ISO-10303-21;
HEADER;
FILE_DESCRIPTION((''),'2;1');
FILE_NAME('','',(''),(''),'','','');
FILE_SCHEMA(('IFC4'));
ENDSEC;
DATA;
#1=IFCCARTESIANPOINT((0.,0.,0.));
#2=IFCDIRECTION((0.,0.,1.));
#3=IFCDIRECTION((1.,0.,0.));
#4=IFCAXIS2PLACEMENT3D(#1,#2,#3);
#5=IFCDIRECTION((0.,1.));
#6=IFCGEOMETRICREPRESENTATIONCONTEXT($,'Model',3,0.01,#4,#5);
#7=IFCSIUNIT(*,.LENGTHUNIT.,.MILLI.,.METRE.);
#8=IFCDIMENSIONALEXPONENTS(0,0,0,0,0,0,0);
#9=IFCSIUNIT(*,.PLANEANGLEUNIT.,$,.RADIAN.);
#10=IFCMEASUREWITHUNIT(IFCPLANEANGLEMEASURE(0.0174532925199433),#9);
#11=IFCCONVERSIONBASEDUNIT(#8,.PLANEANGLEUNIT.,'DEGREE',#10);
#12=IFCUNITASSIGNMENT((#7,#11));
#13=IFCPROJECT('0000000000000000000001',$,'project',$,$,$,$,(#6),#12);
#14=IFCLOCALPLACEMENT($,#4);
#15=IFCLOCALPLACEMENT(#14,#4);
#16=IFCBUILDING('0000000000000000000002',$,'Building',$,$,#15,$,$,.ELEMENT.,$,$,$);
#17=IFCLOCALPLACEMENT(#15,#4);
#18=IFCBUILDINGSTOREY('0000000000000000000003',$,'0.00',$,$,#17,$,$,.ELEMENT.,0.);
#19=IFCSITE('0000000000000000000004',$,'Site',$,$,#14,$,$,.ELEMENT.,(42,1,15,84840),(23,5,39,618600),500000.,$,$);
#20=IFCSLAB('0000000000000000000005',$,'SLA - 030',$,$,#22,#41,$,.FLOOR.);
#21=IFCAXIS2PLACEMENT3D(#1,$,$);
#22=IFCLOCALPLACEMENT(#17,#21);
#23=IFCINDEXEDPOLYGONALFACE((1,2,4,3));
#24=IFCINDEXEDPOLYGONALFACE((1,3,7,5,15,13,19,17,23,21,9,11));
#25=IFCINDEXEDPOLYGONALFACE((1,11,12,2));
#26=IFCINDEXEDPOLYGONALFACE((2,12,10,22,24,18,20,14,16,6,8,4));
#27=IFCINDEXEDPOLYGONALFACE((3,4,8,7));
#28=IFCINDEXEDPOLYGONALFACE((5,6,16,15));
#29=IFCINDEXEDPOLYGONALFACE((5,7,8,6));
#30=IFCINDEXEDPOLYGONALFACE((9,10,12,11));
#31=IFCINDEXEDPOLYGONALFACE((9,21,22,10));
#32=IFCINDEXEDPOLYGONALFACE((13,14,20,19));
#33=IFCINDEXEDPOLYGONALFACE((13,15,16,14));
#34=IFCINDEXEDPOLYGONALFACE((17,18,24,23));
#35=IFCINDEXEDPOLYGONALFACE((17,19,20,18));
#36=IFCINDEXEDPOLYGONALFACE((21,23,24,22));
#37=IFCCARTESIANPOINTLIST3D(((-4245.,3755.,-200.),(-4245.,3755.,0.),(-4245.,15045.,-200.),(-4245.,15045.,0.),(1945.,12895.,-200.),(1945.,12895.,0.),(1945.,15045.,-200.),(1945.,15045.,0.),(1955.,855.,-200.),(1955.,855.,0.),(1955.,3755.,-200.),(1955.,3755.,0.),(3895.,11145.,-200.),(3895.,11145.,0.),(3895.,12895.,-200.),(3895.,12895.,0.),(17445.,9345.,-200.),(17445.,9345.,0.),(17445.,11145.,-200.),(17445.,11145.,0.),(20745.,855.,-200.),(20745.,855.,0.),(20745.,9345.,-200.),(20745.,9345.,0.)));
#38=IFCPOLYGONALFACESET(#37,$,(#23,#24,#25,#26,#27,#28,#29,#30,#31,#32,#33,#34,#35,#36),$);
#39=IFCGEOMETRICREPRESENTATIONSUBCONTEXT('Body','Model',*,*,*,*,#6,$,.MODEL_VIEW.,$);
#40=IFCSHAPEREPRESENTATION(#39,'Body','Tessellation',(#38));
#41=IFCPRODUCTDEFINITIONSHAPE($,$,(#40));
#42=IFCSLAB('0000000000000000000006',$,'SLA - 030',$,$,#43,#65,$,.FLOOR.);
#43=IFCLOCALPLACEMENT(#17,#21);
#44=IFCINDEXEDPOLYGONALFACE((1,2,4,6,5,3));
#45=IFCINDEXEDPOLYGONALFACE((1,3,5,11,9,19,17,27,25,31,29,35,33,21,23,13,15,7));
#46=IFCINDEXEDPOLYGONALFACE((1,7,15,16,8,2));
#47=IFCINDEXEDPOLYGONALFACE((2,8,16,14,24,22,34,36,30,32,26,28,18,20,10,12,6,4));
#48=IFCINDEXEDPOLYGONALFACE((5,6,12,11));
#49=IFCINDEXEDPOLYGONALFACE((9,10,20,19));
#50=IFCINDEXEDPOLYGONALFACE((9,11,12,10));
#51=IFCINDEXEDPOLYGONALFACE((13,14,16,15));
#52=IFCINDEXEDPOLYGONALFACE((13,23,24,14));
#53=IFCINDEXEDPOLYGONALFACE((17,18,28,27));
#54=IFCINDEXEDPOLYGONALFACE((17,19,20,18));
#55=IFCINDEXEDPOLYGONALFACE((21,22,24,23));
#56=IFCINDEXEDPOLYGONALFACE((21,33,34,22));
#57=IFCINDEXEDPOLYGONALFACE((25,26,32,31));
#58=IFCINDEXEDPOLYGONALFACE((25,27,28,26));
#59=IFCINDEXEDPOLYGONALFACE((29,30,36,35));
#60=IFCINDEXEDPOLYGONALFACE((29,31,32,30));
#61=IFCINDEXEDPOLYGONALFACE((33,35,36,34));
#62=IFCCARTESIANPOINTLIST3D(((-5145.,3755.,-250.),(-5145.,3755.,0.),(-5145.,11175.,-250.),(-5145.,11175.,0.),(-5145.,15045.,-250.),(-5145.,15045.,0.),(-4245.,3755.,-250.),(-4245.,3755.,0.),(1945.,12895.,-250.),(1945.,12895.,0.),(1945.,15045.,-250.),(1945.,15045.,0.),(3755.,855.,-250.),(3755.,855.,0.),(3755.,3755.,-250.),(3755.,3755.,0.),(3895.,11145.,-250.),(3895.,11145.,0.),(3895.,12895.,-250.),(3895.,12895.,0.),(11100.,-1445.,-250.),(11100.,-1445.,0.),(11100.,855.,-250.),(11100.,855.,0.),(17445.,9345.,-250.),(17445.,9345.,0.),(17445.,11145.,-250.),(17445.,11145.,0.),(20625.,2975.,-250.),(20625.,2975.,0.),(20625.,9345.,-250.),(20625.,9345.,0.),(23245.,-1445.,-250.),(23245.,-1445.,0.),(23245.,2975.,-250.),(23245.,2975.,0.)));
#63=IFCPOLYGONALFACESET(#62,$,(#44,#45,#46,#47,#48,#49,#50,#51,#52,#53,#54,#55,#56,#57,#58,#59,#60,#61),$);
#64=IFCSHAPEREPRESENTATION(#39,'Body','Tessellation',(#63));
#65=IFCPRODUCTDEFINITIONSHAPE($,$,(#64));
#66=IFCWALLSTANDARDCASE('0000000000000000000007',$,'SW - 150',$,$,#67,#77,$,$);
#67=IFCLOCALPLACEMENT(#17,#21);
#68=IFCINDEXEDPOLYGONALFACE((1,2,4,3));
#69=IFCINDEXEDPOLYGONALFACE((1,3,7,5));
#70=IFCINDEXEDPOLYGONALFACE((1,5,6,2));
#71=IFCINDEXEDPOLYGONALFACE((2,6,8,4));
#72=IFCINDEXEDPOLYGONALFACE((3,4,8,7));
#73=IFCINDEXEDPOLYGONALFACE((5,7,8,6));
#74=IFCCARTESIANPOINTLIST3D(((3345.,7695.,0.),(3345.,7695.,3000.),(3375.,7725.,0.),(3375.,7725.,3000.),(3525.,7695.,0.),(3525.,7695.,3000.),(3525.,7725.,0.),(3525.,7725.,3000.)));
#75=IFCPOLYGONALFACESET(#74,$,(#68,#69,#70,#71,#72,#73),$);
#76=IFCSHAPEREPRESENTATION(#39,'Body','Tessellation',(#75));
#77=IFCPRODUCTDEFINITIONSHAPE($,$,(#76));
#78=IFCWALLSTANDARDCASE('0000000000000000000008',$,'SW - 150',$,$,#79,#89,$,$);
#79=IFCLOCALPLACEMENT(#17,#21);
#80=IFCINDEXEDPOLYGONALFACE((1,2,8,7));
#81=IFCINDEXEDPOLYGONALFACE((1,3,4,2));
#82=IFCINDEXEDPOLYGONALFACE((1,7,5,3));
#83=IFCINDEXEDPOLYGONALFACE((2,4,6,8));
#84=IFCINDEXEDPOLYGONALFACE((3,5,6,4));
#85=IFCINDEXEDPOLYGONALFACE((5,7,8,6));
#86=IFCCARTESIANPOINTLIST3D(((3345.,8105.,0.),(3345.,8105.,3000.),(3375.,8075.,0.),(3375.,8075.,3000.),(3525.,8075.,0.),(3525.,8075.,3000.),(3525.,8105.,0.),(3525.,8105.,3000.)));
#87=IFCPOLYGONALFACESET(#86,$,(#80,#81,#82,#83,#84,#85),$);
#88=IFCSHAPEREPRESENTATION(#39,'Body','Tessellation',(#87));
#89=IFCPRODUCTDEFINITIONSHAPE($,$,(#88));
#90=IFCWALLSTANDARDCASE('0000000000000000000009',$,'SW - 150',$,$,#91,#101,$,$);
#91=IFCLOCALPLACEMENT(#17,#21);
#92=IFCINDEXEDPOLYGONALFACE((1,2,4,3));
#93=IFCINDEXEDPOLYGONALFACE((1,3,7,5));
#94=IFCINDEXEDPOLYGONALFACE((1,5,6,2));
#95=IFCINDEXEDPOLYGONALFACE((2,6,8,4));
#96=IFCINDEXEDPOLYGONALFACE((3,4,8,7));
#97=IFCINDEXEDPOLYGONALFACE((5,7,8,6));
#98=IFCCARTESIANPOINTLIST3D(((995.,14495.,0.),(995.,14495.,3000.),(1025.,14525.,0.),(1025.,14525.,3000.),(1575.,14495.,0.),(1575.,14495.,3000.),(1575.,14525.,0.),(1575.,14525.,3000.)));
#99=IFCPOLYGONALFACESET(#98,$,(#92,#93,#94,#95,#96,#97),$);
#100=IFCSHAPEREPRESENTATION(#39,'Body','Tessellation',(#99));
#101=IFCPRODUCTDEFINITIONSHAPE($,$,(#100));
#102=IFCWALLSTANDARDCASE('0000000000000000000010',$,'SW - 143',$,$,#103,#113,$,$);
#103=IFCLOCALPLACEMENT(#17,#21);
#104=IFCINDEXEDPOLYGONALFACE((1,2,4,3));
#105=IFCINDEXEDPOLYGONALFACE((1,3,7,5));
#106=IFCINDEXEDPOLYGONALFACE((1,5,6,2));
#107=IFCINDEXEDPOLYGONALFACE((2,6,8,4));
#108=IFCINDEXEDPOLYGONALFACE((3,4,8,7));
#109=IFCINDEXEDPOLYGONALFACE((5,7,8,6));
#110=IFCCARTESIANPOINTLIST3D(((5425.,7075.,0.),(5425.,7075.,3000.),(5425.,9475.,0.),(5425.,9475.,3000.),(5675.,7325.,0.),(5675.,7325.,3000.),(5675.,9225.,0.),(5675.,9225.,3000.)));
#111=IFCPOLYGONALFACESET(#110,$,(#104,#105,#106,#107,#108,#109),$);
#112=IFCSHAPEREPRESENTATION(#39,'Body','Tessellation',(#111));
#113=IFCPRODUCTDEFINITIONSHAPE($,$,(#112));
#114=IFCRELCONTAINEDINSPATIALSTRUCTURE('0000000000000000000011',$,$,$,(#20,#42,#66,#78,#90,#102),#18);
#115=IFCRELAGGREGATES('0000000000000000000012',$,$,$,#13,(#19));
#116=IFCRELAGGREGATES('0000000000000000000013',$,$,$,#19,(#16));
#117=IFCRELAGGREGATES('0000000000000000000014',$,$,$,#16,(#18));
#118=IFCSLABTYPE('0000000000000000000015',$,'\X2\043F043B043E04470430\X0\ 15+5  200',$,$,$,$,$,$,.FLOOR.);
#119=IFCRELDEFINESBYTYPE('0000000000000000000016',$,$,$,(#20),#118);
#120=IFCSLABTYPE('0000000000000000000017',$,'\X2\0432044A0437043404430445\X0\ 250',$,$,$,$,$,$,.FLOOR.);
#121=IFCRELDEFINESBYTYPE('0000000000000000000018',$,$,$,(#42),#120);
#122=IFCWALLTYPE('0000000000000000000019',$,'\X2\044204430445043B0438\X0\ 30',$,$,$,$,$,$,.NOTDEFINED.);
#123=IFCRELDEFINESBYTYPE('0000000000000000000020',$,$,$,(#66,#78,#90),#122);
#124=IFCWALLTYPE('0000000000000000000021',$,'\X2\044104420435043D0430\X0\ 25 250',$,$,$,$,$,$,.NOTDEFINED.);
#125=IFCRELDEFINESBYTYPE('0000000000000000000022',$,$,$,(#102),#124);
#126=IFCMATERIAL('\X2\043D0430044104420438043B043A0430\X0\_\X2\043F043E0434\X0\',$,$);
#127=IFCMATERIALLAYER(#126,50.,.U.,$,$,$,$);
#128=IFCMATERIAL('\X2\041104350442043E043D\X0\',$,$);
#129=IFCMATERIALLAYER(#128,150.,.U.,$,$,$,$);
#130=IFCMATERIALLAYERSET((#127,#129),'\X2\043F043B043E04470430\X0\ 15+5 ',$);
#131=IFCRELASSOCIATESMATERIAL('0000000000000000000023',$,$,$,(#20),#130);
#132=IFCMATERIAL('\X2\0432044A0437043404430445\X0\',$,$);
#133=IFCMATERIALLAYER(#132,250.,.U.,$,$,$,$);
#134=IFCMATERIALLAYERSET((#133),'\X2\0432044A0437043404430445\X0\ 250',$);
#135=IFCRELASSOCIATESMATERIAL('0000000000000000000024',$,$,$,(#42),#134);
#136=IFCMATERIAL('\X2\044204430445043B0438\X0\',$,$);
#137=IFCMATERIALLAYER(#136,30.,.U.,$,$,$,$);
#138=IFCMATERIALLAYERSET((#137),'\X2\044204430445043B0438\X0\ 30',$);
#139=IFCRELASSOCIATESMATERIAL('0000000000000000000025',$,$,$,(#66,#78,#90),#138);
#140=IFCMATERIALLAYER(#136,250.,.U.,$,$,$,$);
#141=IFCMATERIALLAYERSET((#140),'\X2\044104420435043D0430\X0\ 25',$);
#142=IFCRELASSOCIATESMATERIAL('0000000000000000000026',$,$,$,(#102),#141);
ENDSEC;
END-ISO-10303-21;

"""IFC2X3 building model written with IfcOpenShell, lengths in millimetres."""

from ifc_helpers import new_model, entity, si_unit, converted_unit, direction, frame, origin_with_axes, place, context, subcontext, project, spatial, polyline, outline, extrude, material, layer, layer_set, layer_usage, type_object, element, save


model = new_model("IFC2X3")

# Units and contexts
model_context = context("Model", 3, precision=0.01, world=origin_with_axes(), true_north=direction((0.0, 1.0)))
body_context = subcontext(model_context, "Body", "Model", "MODEL_VIEW")
ifc_project = project(units=[si_unit("LENGTHUNIT", "METRE", prefix="MILLI"), converted_unit("PLANEANGLEUNIT", "DEGREE", entity("IfcPlaneAngleMeasure", 0.0174532925199433), si_unit("PLANEANGLEUNIT", "RADIAN"), dimensions=[0, 0, 0, 0, 0, 0, 0])], contexts=[model_context])

# Site, building, storey
site_placement = place(None, origin_with_axes())
site = spatial("IfcSite", under=ifc_project, at=site_placement, Name="Site", CompositionType="ELEMENT", RefLatitude=(42, 1, 15, 84840), RefLongitude=(23, 5, 39, 618600), RefElevation=500000.0)
building_placement = place(site_placement, origin_with_axes())
building = spatial("IfcBuilding", under=site, at=building_placement, Name="Building", CompositionType="ELEMENT")
storey_placement = place(building_placement, origin_with_axes())
storey = spatial("IfcBuildingStorey", under=building, at=storey_placement, Name="0.00", CompositionType="ELEMENT", Elevation=0.0)

# Slabs
ifc_material_1 = material(Name="настилка_под")
ifc_layer_1 = layer(ifc_material_1, 50.0, ventilated="UNKNOWN")
ifc_material_2 = material(Name="Бетон")
ifc_layer_2 = layer(ifc_material_2, 150.0, ventilated="UNKNOWN")
ifc_layer_set_1 = layer_set([ifc_layer_1, ifc_layer_2], Name="плоча 15+5 ")
ifc_layer_usage_1 = layer_usage(ifc_layer_set_1, "AXIS3", "NEGATIVE", 200.0)
slab_type_1 = type_object("IfcSlabType", Name="плоча 15+5  200", PredefinedType="FLOOR")
slab_1_placement = place(storey_placement, frame((-4245.0, 15045.0, 0.0), z_axis=(0.0, 0.0, 1.0), x_axis=(1.0, 0.0, 0.0)))
element("IfcSlab", 1, at=slab_1_placement, inside=storey, type_object=slab_type_1, material=ifc_layer_usage_1, Name="SLA - 030", PredefinedType="FLOOR", context=body_context, shape_type="SweptSolid", body=[
    extrude(outline(polyline([(0.0, 0.0), (0.0, -11290.0), (6200.0, -11290.0), (6200.0, -14190.0), (24990.0, -14190.0), (24990.0, -5700.0), (21690.0, -5700.0), (21690.0, -3900.0), (8140.0, -3900.0), (8140.0, -2150.0), (6190.0, -2150.0), (6190.0, 0.0), (0.0, 0.0)])), frame((0.0, 0.0, -200.0), z_axis=(0.0, 0.0, 1.0), x_axis=(1.0, 0.0, 0.0)), (0.0, 0.0, 1.0), 200.0),
])
ifc_material_3 = material(Name="въздух")
ifc_layer_3 = layer(ifc_material_3, 250.0, ventilated="UNKNOWN")
ifc_layer_set_2 = layer_set([ifc_layer_3], Name="въздух 250")
ifc_layer_usage_2 = layer_usage(ifc_layer_set_2, "AXIS3", "NEGATIVE", 250.0)
slab_type_2 = type_object("IfcSlabType", Name="въздух 250", PredefinedType="FLOOR")
slab_2_placement = place(storey_placement, frame((-5145.0, 11175.0, 0.0), z_axis=(0.0, 0.0, 1.0), x_axis=(1.0, 0.0, 0.0)))
element("IfcSlab", 2, at=slab_2_placement, inside=storey, type_object=slab_type_2, material=ifc_layer_usage_2, Name="SLA - 030", PredefinedType="FLOOR", context=body_context, shape_type="SweptSolid", body=[
    extrude(outline(polyline([(0.0, 0.0), (0.0, -7420.0), (900.0, -7420.0), (8900.0, -7420.0), (8900.0, -10320.0), (16245.0, -10320.0), (16245.0, -12620.0), (28390.0, -12620.0), (28390.0, -8200.0), (25770.0, -8200.0), (25770.0, -1830.0), (22590.0, -1830.0), (22590.0, -30.0), (9040.0, -30.0), (9040.0, 1720.0), (7090.0, 1720.0), (7090.0, 3870.0), (0.0, 3870.0), (0.0, 0.0)])), frame((0.0, 0.0, -250.0), z_axis=(0.0, 0.0, 1.0), x_axis=(1.0, 0.0, 0.0)), (0.0, 0.0, 1.0), 250.0),
])

# Walls
ifc_material_4 = material(Name="тухли")
ifc_layer_4 = layer(ifc_material_4, 30.0, ventilated="UNKNOWN")
ifc_layer_set_3 = layer_set([ifc_layer_4], Name="тухли 30")
ifc_layer_usage_3 = layer_usage(ifc_layer_set_3, "AXIS2", "NEGATIVE", 0.0)
wall_type_1 = type_object("IfcWallType", Name="тухли 30", PredefinedType="NOTDEFINED")
wall_1_placement = place(storey_placement, frame((3525.0, 7695.0, 0.0), z_axis=(0.0, 0.0, 1.0), x_axis=(-1.0, 0.0, 0.0)))
element("IfcWallStandardCase", 3, at=wall_1_placement, inside=storey, type_object=wall_type_1, material=ifc_layer_usage_3, Name="SW - 150", context=body_context, shape_type="SweptSolid", body=[
    extrude(outline(polyline([(0.0, -30.0), (150.0, -30.0), (180.0, 0.0), (0.0, 0.0), (0.0, -30.0)])), origin_with_axes(), (0.0, 0.0, 1.0), 3000.0),
])
ifc_layer_usage_4 = layer_usage(ifc_layer_set_3, "AXIS2", "POSITIVE", 0.0)
wall_2_placement = place(storey_placement, frame((3525.0, 8105.0, 0.0), z_axis=(0.0, 0.0, 1.0), x_axis=(-1.0, 0.0, 0.0)))
element("IfcWallStandardCase", 4, at=wall_2_placement, inside=storey, type_object=wall_type_1, material=ifc_layer_usage_4, Name="SW - 150", context=body_context, shape_type="SweptSolid", body=[
    extrude(outline(polyline([(0.0, 0.0), (180.0, 0.0), (150.0, 30.0), (0.0, 30.0), (0.0, 0.0)])), origin_with_axes(), (0.0, 0.0, 1.0), 3000.0),
])
ifc_layer_usage_5 = layer_usage(ifc_layer_set_3, "AXIS2", "POSITIVE", 0.0)
wall_3_placement = place(storey_placement, frame((995.0, 14495.0, 0.0), z_axis=(0.0, 0.0, 1.0), x_axis=(1.0, 0.0, 0.0)))
element("IfcWallStandardCase", 5, at=wall_3_placement, inside=storey, type_object=wall_type_1, material=ifc_layer_usage_5, Name="SW - 150", context=body_context, shape_type="SweptSolid", body=[
    extrude(outline(polyline([(0.0, 0.0), (580.0, 0.0), (580.0, 30.0), (30.0, 30.0), (0.0, 0.0)])), origin_with_axes(), (0.0, 0.0, 1.0), 3000.0),
])
ifc_layer_5 = layer(ifc_material_4, 250.0, ventilated="UNKNOWN")
ifc_layer_set_4 = layer_set([ifc_layer_5], Name="стена 25")
ifc_layer_usage_6 = layer_usage(ifc_layer_set_4, "AXIS2", "POSITIVE", 0.0)
wall_type_2 = type_object("IfcWallType", Name="стена 25 250", PredefinedType="NOTDEFINED")
wall_4_placement = place(storey_placement, frame((5425.0, 9475.0, 0.0), z_axis=(0.0, 0.0, 1.0), x_axis=(0.0, -1.0, 0.0)))
element("IfcWallStandardCase", 6, at=wall_4_placement, inside=storey, type_object=wall_type_2, material=ifc_layer_usage_6, Name="SW - 143", context=body_context, shape_type="SweptSolid", body=[
    extrude(outline(polyline([(0.0, 0.0), (2400.0, 0.0), (2150.0, 250.0), (250.0, 250.0), (0.0, 0.0)])), origin_with_axes(), (0.0, 0.0, 1.0), 3000.0),
])

save(model, "model.ifc")
